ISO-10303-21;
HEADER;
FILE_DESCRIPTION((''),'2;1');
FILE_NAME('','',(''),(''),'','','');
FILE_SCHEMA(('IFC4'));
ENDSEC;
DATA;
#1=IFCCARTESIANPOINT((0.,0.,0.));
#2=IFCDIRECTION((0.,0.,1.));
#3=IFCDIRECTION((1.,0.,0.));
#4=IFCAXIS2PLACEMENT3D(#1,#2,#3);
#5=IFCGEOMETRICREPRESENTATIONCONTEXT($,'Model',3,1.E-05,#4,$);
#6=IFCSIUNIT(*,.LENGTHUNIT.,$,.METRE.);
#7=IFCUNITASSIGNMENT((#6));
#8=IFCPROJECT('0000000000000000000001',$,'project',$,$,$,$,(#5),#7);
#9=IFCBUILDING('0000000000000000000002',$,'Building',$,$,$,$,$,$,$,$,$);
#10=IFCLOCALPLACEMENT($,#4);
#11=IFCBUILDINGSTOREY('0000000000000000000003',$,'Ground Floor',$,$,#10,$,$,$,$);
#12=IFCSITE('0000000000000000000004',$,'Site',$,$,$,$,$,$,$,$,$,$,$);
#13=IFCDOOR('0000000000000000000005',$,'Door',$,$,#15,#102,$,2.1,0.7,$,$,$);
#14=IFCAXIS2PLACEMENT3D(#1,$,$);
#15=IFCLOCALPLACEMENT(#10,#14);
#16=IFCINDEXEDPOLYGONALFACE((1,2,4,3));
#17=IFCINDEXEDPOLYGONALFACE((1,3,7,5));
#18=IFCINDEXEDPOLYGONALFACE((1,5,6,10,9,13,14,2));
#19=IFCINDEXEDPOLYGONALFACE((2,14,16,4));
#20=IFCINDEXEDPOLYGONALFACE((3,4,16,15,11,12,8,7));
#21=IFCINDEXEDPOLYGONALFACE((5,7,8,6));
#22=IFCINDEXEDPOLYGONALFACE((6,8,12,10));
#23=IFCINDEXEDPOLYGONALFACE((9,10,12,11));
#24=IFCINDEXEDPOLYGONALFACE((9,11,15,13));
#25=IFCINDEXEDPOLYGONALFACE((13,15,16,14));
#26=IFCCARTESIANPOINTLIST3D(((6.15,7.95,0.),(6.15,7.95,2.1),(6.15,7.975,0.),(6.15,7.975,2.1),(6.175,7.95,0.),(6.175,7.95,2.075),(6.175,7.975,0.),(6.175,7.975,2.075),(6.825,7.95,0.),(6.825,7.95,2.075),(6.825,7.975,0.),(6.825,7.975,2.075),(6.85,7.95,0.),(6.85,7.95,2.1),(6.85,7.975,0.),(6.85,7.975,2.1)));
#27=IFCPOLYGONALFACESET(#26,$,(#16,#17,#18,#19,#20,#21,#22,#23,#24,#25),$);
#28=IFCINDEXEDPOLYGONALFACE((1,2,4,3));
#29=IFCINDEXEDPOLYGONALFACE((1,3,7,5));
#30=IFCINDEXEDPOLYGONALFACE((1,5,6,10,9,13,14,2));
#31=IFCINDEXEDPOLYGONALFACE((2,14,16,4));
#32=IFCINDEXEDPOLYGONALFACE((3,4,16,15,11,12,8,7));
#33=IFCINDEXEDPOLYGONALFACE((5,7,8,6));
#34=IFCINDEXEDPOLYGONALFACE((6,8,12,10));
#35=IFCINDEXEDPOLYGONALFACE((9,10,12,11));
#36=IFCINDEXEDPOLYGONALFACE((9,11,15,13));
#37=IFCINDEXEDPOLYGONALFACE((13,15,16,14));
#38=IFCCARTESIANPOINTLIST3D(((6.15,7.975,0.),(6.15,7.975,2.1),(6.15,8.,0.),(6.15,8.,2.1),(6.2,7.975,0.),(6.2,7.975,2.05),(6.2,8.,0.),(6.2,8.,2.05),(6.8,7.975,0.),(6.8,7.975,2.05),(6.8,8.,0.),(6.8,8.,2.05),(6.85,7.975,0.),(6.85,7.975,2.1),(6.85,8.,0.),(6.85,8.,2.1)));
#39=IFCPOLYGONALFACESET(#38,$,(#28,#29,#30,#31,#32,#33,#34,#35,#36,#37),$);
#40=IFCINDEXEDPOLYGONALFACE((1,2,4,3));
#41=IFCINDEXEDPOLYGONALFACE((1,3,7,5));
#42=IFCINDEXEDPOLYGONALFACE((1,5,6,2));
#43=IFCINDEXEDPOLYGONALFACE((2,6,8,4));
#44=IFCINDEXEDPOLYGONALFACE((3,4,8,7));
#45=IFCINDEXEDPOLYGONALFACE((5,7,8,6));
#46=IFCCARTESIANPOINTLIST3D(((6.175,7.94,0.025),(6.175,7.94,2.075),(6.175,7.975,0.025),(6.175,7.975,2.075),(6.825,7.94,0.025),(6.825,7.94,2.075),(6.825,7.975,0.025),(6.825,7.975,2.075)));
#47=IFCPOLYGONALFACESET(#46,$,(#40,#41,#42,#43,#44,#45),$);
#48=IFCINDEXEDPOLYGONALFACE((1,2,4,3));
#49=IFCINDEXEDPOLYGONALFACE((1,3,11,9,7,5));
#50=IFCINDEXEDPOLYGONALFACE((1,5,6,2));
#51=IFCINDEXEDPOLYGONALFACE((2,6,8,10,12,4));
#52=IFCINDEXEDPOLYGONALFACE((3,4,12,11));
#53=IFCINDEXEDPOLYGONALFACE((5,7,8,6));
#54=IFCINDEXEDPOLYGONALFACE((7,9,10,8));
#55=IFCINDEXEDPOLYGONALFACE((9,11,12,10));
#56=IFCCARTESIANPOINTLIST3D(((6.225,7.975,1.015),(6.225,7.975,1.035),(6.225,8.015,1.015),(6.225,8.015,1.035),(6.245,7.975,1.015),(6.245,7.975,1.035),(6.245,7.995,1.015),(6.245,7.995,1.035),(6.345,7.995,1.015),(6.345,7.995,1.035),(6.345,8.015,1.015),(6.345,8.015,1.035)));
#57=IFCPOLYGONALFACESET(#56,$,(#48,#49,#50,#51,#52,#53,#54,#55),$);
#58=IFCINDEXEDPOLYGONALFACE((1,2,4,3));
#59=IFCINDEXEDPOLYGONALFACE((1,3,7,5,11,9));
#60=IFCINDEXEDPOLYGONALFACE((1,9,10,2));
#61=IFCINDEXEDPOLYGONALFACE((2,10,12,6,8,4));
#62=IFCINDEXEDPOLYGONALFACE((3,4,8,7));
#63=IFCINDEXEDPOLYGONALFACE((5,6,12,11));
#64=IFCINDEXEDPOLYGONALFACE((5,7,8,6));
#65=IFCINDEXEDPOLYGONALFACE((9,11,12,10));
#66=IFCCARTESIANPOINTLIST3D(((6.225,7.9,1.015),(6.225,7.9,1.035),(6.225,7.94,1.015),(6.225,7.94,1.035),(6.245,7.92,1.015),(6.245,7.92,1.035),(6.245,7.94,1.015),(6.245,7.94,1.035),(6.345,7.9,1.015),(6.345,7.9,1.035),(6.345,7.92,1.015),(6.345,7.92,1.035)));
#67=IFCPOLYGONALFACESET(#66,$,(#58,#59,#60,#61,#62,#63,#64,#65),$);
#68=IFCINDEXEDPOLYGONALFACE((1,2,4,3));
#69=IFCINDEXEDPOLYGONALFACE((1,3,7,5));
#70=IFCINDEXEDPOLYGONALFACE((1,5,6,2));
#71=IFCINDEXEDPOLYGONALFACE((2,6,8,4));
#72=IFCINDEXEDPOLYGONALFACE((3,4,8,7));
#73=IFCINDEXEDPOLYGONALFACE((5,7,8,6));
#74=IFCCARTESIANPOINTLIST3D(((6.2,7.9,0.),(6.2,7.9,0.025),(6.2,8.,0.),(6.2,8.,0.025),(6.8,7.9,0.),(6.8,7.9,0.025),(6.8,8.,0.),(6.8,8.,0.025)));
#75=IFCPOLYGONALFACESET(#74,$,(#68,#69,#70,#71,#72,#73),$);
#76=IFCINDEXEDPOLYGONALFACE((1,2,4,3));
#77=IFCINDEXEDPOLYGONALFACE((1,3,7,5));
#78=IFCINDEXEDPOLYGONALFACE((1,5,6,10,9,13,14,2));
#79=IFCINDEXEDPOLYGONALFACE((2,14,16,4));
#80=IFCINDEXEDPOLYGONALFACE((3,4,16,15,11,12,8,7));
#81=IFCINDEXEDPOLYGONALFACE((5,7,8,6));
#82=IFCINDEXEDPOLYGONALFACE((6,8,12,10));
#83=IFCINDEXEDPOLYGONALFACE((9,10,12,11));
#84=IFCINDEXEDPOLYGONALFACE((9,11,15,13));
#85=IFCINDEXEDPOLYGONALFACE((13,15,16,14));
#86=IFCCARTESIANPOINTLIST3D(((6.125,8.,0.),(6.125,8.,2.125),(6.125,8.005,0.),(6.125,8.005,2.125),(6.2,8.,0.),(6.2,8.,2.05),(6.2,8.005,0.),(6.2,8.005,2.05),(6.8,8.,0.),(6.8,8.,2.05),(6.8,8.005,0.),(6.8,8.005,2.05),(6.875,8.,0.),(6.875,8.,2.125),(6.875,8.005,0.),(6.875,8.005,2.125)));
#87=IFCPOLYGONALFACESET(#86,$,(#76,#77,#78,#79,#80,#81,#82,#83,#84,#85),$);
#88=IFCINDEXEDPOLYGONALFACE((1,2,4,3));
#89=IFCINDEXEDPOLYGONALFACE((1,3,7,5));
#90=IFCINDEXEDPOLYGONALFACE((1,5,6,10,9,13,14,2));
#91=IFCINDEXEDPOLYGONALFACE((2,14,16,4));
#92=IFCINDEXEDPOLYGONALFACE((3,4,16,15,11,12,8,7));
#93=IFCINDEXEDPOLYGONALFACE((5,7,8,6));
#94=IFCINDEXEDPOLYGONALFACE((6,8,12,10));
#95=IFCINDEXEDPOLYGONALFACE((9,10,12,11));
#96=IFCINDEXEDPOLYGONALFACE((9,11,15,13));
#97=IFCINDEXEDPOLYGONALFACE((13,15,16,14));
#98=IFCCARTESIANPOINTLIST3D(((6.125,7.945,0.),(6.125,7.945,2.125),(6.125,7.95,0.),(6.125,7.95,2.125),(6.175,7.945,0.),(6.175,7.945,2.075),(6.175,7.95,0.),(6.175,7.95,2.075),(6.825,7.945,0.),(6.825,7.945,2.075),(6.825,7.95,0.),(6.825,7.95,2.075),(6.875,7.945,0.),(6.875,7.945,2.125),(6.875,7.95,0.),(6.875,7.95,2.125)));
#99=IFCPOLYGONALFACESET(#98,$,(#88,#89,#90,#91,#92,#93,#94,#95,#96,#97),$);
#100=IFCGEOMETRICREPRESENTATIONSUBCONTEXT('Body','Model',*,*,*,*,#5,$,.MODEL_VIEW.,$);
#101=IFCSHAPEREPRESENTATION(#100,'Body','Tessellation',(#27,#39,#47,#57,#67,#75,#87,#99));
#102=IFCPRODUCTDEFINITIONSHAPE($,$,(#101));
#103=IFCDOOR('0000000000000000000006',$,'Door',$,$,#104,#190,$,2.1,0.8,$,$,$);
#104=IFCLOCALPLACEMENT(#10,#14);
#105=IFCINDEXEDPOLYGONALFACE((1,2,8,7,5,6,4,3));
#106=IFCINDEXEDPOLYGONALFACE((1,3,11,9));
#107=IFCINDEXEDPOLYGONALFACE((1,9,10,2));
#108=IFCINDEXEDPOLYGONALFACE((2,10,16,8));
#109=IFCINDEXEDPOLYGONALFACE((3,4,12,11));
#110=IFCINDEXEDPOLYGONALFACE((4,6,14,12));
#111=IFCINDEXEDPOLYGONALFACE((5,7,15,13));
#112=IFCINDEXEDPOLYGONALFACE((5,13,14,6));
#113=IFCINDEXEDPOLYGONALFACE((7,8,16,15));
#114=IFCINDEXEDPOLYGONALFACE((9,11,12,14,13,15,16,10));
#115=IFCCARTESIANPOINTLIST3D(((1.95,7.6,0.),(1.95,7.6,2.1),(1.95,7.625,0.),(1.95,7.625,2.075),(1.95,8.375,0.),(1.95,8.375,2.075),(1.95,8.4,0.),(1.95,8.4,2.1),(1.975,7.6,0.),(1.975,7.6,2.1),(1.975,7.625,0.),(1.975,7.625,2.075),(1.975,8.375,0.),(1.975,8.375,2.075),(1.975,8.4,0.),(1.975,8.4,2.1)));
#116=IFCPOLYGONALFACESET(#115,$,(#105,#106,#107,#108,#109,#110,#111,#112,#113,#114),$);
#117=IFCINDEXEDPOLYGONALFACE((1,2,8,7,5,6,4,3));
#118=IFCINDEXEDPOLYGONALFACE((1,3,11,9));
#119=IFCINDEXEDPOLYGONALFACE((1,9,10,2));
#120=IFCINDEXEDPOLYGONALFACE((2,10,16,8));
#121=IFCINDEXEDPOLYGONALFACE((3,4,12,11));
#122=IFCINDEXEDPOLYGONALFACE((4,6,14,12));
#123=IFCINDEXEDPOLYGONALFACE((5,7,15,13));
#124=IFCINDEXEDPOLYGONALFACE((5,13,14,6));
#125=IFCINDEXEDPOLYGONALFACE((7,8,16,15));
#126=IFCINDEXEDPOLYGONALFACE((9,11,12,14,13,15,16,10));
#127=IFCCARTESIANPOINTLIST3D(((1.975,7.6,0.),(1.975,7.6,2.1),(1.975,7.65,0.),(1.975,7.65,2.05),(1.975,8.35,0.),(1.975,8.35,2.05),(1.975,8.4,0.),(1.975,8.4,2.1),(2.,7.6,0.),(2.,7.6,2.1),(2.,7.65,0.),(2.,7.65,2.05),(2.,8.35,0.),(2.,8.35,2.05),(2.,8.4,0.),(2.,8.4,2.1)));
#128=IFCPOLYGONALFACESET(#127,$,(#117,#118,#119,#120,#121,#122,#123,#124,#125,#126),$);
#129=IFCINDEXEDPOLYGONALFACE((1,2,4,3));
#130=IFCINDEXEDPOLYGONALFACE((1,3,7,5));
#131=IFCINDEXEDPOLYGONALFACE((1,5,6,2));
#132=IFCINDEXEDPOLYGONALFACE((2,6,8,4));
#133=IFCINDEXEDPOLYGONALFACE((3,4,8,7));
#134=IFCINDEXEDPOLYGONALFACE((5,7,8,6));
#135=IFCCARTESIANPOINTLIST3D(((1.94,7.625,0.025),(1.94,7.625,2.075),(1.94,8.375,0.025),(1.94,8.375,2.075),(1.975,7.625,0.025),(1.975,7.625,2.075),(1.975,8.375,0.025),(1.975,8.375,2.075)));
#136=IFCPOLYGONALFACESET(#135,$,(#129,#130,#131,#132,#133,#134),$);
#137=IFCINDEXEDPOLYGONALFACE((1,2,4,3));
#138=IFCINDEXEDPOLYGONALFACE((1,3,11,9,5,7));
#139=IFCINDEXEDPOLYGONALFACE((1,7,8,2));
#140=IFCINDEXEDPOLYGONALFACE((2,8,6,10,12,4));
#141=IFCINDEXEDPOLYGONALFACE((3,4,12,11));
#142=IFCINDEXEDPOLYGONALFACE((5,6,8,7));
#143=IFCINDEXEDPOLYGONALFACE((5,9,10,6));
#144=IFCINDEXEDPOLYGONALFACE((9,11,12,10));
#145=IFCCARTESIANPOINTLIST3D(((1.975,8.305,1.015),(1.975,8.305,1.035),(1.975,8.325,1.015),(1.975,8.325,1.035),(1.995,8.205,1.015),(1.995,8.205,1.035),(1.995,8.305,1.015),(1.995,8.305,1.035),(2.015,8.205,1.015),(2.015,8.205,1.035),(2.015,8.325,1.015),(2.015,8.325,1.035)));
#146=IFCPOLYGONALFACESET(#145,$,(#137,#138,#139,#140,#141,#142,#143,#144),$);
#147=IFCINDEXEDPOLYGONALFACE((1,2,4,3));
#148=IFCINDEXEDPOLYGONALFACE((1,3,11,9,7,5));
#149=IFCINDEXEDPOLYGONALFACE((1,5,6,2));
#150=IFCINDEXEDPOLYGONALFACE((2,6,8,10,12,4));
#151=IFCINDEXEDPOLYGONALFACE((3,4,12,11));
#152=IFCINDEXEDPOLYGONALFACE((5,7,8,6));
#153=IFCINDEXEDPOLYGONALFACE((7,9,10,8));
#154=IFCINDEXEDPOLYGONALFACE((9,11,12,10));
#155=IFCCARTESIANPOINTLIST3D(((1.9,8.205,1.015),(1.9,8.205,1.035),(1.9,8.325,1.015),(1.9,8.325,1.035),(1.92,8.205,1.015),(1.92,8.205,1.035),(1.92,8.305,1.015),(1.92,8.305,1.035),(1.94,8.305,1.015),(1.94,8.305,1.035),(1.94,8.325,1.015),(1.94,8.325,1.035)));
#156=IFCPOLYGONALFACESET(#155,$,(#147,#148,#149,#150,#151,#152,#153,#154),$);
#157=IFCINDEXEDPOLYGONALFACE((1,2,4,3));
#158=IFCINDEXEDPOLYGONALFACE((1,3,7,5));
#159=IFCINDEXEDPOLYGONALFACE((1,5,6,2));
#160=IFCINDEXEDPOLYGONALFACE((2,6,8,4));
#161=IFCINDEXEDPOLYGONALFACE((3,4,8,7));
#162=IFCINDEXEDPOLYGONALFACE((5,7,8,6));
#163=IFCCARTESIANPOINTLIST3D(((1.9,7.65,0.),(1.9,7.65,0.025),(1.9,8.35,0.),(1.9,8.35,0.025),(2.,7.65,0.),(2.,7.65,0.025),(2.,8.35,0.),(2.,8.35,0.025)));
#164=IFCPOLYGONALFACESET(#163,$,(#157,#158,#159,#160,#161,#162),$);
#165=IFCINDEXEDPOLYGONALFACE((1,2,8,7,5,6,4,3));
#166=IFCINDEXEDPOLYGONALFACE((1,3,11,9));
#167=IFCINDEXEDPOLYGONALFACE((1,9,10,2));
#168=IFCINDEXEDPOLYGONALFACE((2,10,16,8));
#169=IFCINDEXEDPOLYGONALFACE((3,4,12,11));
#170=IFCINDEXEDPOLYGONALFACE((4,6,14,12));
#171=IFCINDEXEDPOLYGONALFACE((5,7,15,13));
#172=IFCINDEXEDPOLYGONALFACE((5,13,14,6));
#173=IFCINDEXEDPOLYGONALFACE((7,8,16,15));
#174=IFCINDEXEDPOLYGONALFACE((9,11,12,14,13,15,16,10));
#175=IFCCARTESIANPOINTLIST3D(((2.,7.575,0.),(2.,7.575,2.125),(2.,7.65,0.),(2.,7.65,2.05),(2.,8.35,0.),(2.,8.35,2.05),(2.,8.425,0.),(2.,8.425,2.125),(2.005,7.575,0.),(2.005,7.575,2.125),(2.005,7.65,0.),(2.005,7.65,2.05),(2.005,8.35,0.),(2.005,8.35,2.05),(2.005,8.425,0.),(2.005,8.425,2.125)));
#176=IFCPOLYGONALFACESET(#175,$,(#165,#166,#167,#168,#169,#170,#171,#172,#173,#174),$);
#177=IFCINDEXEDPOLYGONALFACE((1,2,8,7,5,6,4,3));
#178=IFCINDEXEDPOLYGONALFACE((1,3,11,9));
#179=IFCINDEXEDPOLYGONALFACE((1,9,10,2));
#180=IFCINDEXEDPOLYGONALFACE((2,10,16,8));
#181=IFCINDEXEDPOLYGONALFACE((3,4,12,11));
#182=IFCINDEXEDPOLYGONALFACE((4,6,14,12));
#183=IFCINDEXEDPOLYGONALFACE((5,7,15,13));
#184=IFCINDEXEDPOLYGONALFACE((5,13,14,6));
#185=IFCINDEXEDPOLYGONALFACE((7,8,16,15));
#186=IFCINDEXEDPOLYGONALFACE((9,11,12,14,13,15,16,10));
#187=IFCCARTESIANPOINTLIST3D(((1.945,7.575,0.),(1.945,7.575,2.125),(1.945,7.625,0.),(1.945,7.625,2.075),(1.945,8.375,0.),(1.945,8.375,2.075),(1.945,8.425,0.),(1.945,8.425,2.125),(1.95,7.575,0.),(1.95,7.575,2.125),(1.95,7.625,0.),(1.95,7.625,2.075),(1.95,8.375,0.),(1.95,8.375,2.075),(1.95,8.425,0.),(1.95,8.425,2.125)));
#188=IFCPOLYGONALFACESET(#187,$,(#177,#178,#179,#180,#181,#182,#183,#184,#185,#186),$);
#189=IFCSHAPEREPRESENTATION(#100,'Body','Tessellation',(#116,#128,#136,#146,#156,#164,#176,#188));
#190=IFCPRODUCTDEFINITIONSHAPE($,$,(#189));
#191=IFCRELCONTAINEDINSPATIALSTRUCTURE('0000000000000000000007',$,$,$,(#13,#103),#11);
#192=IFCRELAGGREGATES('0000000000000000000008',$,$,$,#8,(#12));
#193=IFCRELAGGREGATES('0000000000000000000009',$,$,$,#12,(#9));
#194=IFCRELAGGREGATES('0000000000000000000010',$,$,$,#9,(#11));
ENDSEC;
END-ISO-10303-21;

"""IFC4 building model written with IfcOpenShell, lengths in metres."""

from ifc_helpers import new_model, si_unit, frame, origin_with_axes, place, context, subcontext, project, spatial, line, indexed_curve, outline, extrude, element, save


model = new_model("IFC4")

# Units and contexts
model_context = context("Model", 3, precision=1e-05, world=origin_with_axes())
body_context = subcontext(model_context, "Body", "Model", "MODEL_VIEW")
ifc_project = project(units=[si_unit("LENGTHUNIT", "METRE")], contexts=[model_context])

# Site, building, storey
site = spatial("IfcSite", under=ifc_project, Name="Site")
building = spatial("IfcBuilding", under=site, Name="Building")
storey_placement = place(None, origin_with_axes())
storey = spatial("IfcBuildingStorey", under=building, at=storey_placement, Name="Ground Floor")

# Doors
door_1_placement = place(storey_placement, frame((6.85, 8.0, 0.0), z_axis=(0.0, 0.0, 1.0), x_axis=(-1.0, 0.0, 0.0)))
element("IfcDoor", 1, at=door_1_placement, inside=storey, Name="Door", OverallHeight=2.1, OverallWidth=0.7, context=body_context, shape_type="SweptSolid", body=[
    extrude(outline(indexed_curve([(0.0, 0.0), (0.0, 2.1), (0.7, 2.1), (0.7, 0.0), (0.675, 0.0), (0.675, 2.075), (0.025, 2.075), (0.025, 0.0)], segments=[line(1, 2, 3, 4, 5, 6, 7, 8, 1)])), frame((0.0, 0.025, 0.0), z_axis=(0.0, -1.0, 0.0), x_axis=(1.0, 0.0, 0.0)), (0.0, 0.0, -1.0), 0.025),
    extrude(outline(indexed_curve([(0.0, 0.0), (0.0, 2.1), (0.7, 2.1), (0.7, 0.0), (0.65, 0.0), (0.65, 2.05), (0.05, 2.05), (0.05, 0.0)], segments=[line(1, 2, 3, 4, 5, 6, 7, 8, 1)])), frame((0.0, 0.0, 0.0), z_axis=(0.0, -1.0, 0.0), x_axis=(1.0, 0.0, 0.0)), (0.0, 0.0, -1.0), 0.025),
    extrude(outline(indexed_curve([(0.0, 0.0), (0.65, 0.0), (0.65, 0.035), (0.0, 0.035)], segments=[line(1, 2, 3, 4, 1)])), frame((0.025, 0.025, 0.025), z_axis=(0.0, 0.0, 1.0), x_axis=(1.0, 0.0, 0.0)), (0.0, 0.0, 1.0), 2.05),
    extrude(outline(indexed_curve([(0.0, 0.0), (0.0, -0.04), (-0.12, -0.04), (-0.12, -0.02), (-0.02, -0.02), (-0.02, 0.0)], segments=[line(1, 2, 3, 4, 5, 6, 1)])), frame((0.625, 0.025, 1.015), z_axis=(0.0, 0.0, 1.0), x_axis=(1.0, 0.0, 0.0)), (0.0, 0.0, 1.0), 0.02),
    extrude(outline(indexed_curve([(0.0, 0.0), (0.0, 0.04), (-0.12, 0.04), (-0.12, 0.02), (-0.02, 0.02), (-0.02, 0.0)], segments=[line(1, 2, 3, 4, 5, 6, 1)])), frame((0.625, 0.06, 1.015), z_axis=(0.0, 0.0, 1.0), x_axis=(1.0, 0.0, 0.0)), (0.0, 0.0, 1.0), 0.02),
    extrude(outline(indexed_curve([(0.0, 0.0), (0.6, 0.0), (0.6, 0.1), (0.0, 0.1)], segments=[line(1, 2, 3, 4, 1)])), frame((0.05, 0.0, 0.0), z_axis=(0.0, 0.0, 1.0), x_axis=(1.0, 0.0, 0.0)), (0.0, 0.0, 1.0), 0.025),
    extrude(outline(indexed_curve([(0.0, 0.0), (0.0, 2.125), (0.75, 2.125), (0.75, 0.0), (0.675, 0.0), (0.675, 2.05), (0.075, 2.05), (0.075, 0.0)], segments=[line(1, 2, 3, 4, 5, 6, 7, 8, 1)])), frame((-0.025, -0.005, 0.0), z_axis=(0.0, -1.0, 0.0), x_axis=(1.0, 0.0, 0.0)), (0.0, 0.0, -1.0), 0.005),
    extrude(outline(indexed_curve([(0.0, 0.0), (0.0, 2.125), (0.75, 2.125), (0.75, 0.0), (0.7, 0.0), (0.7, 2.075), (0.05, 2.075), (0.05, 0.0)], segments=[line(1, 2, 3, 4, 5, 6, 7, 8, 1)])), frame((-0.025, 0.05, 0.0), z_axis=(0.0, -1.0, 0.0), x_axis=(1.0, 0.0, 0.0)), (0.0, 0.0, -1.0), 0.005),
])
door_2_placement = place(storey_placement, frame((2.0, 7.6, 0.0), z_axis=(0.0, 0.0, 1.0), x_axis=(0.0, 1.0, 0.0)))
element("IfcDoor", 2, at=door_2_placement, inside=storey, Name="Door", OverallHeight=2.1, OverallWidth=0.8, context=body_context, shape_type="SweptSolid", body=[
    extrude(outline(indexed_curve([(0.0, 0.0), (0.0, 2.1), (0.8, 2.1), (0.8, 0.0), (0.775, 0.0), (0.775, 2.075), (0.025, 2.075), (0.025, 0.0)], segments=[line(1, 2, 3, 4, 5, 6, 7, 8, 1)])), frame((0.0, 0.025, 0.0), z_axis=(0.0, -1.0, 0.0), x_axis=(1.0, 0.0, 0.0)), (0.0, 0.0, -1.0), 0.025),
    extrude(outline(indexed_curve([(0.0, 0.0), (0.0, 2.1), (0.8, 2.1), (0.8, 0.0), (0.75, 0.0), (0.75, 2.05), (0.05, 2.05), (0.05, 0.0)], segments=[line(1, 2, 3, 4, 5, 6, 7, 8, 1)])), frame((0.0, 0.0, 0.0), z_axis=(0.0, -1.0, 0.0), x_axis=(1.0, 0.0, 0.0)), (0.0, 0.0, -1.0), 0.025),
    extrude(outline(indexed_curve([(0.0, 0.0), (0.75, 0.0), (0.75, 0.035), (0.0, 0.035)], segments=[line(1, 2, 3, 4, 1)])), frame((0.025, 0.025, 0.025), z_axis=(0.0, 0.0, 1.0), x_axis=(1.0, 0.0, 0.0)), (0.0, 0.0, 1.0), 2.05),
    extrude(outline(indexed_curve([(0.0, 0.0), (0.0, -0.04), (-0.12, -0.04), (-0.12, -0.02), (-0.02, -0.02), (-0.02, 0.0)], segments=[line(1, 2, 3, 4, 5, 6, 1)])), frame((0.725, 0.025, 1.015), z_axis=(0.0, 0.0, 1.0), x_axis=(1.0, 0.0, 0.0)), (0.0, 0.0, 1.0), 0.02),
    extrude(outline(indexed_curve([(0.0, 0.0), (0.0, 0.04), (-0.12, 0.04), (-0.12, 0.02), (-0.02, 0.02), (-0.02, 0.0)], segments=[line(1, 2, 3, 4, 5, 6, 1)])), frame((0.725, 0.06, 1.015), z_axis=(0.0, 0.0, 1.0), x_axis=(1.0, 0.0, 0.0)), (0.0, 0.0, 1.0), 0.02),
    extrude(outline(indexed_curve([(0.0, 0.0), (0.7, 0.0), (0.7, 0.1), (0.0, 0.1)], segments=[line(1, 2, 3, 4, 1)])), frame((0.05, 0.0, 0.0), z_axis=(0.0, 0.0, 1.0), x_axis=(1.0, 0.0, 0.0)), (0.0, 0.0, 1.0), 0.025),
    extrude(outline(indexed_curve([(0.0, 0.0), (0.0, 2.125), (0.85, 2.125), (0.85, 0.0), (0.775, 0.0), (0.775, 2.05), (0.075, 2.05), (0.075, 0.0)], segments=[line(1, 2, 3, 4, 5, 6, 7, 8, 1)])), frame((-0.025, -0.005, 0.0), z_axis=(0.0, -1.0, 0.0), x_axis=(1.0, 0.0, 0.0)), (0.0, 0.0, -1.0), 0.005),
    extrude(outline(indexed_curve([(0.0, 0.0), (0.0, 2.125), (0.85, 2.125), (0.85, 0.0), (0.8, 0.0), (0.8, 2.075), (0.05, 2.075), (0.05, 0.0)], segments=[line(1, 2, 3, 4, 5, 6, 7, 8, 1)])), frame((-0.025, 0.05, 0.0), z_axis=(0.0, -1.0, 0.0), x_axis=(1.0, 0.0, 0.0)), (0.0, 0.0, -1.0), 0.005),
])

save(model, "model.ifc")
